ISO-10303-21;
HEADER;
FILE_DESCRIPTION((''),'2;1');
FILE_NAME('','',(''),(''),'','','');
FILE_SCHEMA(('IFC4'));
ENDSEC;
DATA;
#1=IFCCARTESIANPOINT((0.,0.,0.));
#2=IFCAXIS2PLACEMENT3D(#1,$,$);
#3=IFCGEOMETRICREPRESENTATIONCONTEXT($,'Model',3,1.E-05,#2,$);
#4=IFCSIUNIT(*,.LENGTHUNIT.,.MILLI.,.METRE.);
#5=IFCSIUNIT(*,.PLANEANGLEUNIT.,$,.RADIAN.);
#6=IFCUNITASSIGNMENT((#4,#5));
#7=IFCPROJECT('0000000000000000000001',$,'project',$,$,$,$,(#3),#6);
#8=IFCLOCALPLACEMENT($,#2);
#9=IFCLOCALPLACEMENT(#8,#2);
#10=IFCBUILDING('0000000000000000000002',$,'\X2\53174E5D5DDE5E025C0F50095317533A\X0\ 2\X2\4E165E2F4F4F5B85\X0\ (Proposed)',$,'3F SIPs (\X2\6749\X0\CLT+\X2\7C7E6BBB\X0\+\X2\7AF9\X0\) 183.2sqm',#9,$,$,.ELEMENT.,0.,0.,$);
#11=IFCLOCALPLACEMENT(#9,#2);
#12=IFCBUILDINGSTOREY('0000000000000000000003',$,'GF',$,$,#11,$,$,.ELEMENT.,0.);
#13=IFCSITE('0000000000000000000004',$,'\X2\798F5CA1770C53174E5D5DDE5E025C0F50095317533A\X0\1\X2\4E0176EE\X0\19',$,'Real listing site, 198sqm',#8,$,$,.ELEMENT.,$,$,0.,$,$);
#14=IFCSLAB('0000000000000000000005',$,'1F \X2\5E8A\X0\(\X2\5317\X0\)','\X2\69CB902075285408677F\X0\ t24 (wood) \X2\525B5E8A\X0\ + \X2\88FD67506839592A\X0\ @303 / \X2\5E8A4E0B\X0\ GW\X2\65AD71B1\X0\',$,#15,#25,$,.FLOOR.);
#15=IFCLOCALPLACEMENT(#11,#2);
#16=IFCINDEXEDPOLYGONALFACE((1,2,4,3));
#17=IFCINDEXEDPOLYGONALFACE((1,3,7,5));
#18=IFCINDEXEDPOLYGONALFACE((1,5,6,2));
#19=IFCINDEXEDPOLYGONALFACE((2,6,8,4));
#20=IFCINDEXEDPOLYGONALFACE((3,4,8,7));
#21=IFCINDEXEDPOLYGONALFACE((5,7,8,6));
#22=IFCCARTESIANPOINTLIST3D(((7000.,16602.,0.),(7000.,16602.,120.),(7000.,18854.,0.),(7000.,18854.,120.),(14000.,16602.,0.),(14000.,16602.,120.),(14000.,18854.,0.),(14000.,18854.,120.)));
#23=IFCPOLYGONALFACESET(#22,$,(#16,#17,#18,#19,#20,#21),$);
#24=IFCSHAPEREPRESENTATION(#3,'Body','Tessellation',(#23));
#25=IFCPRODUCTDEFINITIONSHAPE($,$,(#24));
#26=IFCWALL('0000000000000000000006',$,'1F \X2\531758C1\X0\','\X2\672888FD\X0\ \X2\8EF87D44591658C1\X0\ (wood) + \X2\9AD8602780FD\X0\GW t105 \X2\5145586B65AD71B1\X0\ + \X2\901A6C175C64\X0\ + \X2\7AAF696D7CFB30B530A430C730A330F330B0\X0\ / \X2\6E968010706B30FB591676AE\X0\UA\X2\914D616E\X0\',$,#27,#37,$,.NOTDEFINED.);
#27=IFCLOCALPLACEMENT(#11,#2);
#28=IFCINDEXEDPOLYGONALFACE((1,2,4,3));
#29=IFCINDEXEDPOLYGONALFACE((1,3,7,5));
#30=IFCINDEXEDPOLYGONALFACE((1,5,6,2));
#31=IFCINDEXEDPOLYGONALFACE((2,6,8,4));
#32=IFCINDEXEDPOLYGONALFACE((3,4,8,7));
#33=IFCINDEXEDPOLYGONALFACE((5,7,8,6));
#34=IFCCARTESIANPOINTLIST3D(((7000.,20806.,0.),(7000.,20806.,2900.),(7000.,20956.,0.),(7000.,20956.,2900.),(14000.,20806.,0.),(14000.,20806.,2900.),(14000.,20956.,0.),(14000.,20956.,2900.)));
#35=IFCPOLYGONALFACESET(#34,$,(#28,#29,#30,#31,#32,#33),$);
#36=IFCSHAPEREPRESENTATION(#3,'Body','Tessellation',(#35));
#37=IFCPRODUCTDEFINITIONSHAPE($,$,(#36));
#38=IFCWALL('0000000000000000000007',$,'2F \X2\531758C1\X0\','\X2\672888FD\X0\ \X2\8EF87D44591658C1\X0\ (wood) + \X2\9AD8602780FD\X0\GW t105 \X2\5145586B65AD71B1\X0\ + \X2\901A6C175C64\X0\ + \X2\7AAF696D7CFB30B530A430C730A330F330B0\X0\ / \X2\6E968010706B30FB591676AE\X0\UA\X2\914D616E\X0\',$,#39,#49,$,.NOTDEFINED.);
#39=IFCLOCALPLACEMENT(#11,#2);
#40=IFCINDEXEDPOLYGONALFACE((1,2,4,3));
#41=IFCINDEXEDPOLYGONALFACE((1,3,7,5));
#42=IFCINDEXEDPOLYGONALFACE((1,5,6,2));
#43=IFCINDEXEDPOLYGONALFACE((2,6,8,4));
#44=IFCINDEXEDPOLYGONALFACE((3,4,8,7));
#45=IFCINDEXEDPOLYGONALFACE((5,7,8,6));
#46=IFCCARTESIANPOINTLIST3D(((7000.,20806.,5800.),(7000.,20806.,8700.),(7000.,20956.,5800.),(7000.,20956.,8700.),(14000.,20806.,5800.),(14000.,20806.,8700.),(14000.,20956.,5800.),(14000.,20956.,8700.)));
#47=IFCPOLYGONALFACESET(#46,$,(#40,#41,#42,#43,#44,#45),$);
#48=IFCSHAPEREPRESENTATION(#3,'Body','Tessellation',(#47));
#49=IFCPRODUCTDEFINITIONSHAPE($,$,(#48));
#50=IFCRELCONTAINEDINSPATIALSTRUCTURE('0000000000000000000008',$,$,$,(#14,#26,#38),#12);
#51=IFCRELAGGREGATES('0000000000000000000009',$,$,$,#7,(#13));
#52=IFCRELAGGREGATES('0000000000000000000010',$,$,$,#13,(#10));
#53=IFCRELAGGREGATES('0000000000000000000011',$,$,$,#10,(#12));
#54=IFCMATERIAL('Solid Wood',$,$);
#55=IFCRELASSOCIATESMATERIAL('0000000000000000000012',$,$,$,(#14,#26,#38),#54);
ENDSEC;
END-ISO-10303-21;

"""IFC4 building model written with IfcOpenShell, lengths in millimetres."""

from ifc_helpers import new_model, si_unit, frame, frame_2d, origin, place, context, project, spatial, rectangle, extrude, material, element, save


model = new_model("IFC4")

# Units and contexts
model_context = context("Model", 3, precision=1e-05, world=origin())
ifc_project = project(units=[si_unit("LENGTHUNIT", "METRE", prefix="MILLI"), si_unit("PLANEANGLEUNIT", "RADIAN")], contexts=[model_context])

# Site, building, storey
site_placement = place(None, origin())
site = spatial("IfcSite", under=ifc_project, at=site_placement, Name="福岡県北九州市小倉北区1丁目19", ObjectType="Real listing site, 198sqm", CompositionType="ELEMENT", RefElevation=0.0)
building_placement = place(site_placement, origin())
building = spatial("IfcBuilding", under=site, at=building_placement, Name="北九州市小倉北区 2世帯住宅 (Proposed)", ObjectType="3F SIPs (杉CLT+籾殻+竹) 183.2sqm", CompositionType="ELEMENT", ElevationOfRefHeight=0.0, ElevationOfTerrain=0.0)
storey_placement = place(building_placement, origin())
storey = spatial("IfcBuildingStorey", under=building, at=storey_placement, Name="GF", CompositionType="ELEMENT", Elevation=0.0)

# Slab
ifc_material_1 = material(Name="Solid Wood")
slab_1_placement = place(storey_placement, frame((3500.0, 8301.0, 0.0)))
element("IfcSlab", 1, at=slab_1_placement, inside=storey, material=ifc_material_1, Name="1F 床(北)", Description="構造用合板 t24 (wood) 剛床 + 製材根太 @303 / 床下 GW断熱", PredefinedType="FLOOR", context=model_context, shape_type="SweptSolid", body=[
    extrude(rectangle(XDim=7000.0, YDim=2252.0, at=frame_2d((3500.0, 1126.0))), frame((3500.0, 8301.0, 0.0)), (0.0, 0.0, 1.0), 120.0),
])

# Wall
wall_1_placement = place(storey_placement, frame((3500.0, 10403.0, 0.0)))
element("IfcWall", 2, at=wall_1_placement, inside=storey, material=ifc_material_1, Name="1F 北壁", Description="木製 軸組外壁 (wood) + 高性能GW t105 充填断熱 + 通気層 + 窯業系サイディング / 準耐火・外皮UA配慮", PredefinedType="NOTDEFINED", context=model_context, shape_type="SweptSolid", body=[
    extrude(rectangle(XDim=7000.0, YDim=150.0, at=frame_2d((3500.0, 75.0))), frame((3500.0, 10403.0, 0.0)), (0.0, 0.0, 1.0), 2900.0),
])

# Wall
wall_2_placement = place(storey_placement, frame((3500.0, 10403.0, 2900.0)))
element("IfcWall", 3, at=wall_2_placement, inside=storey, material=ifc_material_1, Name="2F 北壁", Description="木製 軸組外壁 (wood) + 高性能GW t105 充填断熱 + 通気層 + 窯業系サイディング / 準耐火・外皮UA配慮", PredefinedType="NOTDEFINED", context=model_context, shape_type="SweptSolid", body=[
    extrude(rectangle(XDim=7000.0, YDim=150.0, at=frame_2d((3500.0, 75.0))), frame((3500.0, 10403.0, 2900.0)), (0.0, 0.0, 1.0), 2900.0),
])

save(model, "model.ifc")
